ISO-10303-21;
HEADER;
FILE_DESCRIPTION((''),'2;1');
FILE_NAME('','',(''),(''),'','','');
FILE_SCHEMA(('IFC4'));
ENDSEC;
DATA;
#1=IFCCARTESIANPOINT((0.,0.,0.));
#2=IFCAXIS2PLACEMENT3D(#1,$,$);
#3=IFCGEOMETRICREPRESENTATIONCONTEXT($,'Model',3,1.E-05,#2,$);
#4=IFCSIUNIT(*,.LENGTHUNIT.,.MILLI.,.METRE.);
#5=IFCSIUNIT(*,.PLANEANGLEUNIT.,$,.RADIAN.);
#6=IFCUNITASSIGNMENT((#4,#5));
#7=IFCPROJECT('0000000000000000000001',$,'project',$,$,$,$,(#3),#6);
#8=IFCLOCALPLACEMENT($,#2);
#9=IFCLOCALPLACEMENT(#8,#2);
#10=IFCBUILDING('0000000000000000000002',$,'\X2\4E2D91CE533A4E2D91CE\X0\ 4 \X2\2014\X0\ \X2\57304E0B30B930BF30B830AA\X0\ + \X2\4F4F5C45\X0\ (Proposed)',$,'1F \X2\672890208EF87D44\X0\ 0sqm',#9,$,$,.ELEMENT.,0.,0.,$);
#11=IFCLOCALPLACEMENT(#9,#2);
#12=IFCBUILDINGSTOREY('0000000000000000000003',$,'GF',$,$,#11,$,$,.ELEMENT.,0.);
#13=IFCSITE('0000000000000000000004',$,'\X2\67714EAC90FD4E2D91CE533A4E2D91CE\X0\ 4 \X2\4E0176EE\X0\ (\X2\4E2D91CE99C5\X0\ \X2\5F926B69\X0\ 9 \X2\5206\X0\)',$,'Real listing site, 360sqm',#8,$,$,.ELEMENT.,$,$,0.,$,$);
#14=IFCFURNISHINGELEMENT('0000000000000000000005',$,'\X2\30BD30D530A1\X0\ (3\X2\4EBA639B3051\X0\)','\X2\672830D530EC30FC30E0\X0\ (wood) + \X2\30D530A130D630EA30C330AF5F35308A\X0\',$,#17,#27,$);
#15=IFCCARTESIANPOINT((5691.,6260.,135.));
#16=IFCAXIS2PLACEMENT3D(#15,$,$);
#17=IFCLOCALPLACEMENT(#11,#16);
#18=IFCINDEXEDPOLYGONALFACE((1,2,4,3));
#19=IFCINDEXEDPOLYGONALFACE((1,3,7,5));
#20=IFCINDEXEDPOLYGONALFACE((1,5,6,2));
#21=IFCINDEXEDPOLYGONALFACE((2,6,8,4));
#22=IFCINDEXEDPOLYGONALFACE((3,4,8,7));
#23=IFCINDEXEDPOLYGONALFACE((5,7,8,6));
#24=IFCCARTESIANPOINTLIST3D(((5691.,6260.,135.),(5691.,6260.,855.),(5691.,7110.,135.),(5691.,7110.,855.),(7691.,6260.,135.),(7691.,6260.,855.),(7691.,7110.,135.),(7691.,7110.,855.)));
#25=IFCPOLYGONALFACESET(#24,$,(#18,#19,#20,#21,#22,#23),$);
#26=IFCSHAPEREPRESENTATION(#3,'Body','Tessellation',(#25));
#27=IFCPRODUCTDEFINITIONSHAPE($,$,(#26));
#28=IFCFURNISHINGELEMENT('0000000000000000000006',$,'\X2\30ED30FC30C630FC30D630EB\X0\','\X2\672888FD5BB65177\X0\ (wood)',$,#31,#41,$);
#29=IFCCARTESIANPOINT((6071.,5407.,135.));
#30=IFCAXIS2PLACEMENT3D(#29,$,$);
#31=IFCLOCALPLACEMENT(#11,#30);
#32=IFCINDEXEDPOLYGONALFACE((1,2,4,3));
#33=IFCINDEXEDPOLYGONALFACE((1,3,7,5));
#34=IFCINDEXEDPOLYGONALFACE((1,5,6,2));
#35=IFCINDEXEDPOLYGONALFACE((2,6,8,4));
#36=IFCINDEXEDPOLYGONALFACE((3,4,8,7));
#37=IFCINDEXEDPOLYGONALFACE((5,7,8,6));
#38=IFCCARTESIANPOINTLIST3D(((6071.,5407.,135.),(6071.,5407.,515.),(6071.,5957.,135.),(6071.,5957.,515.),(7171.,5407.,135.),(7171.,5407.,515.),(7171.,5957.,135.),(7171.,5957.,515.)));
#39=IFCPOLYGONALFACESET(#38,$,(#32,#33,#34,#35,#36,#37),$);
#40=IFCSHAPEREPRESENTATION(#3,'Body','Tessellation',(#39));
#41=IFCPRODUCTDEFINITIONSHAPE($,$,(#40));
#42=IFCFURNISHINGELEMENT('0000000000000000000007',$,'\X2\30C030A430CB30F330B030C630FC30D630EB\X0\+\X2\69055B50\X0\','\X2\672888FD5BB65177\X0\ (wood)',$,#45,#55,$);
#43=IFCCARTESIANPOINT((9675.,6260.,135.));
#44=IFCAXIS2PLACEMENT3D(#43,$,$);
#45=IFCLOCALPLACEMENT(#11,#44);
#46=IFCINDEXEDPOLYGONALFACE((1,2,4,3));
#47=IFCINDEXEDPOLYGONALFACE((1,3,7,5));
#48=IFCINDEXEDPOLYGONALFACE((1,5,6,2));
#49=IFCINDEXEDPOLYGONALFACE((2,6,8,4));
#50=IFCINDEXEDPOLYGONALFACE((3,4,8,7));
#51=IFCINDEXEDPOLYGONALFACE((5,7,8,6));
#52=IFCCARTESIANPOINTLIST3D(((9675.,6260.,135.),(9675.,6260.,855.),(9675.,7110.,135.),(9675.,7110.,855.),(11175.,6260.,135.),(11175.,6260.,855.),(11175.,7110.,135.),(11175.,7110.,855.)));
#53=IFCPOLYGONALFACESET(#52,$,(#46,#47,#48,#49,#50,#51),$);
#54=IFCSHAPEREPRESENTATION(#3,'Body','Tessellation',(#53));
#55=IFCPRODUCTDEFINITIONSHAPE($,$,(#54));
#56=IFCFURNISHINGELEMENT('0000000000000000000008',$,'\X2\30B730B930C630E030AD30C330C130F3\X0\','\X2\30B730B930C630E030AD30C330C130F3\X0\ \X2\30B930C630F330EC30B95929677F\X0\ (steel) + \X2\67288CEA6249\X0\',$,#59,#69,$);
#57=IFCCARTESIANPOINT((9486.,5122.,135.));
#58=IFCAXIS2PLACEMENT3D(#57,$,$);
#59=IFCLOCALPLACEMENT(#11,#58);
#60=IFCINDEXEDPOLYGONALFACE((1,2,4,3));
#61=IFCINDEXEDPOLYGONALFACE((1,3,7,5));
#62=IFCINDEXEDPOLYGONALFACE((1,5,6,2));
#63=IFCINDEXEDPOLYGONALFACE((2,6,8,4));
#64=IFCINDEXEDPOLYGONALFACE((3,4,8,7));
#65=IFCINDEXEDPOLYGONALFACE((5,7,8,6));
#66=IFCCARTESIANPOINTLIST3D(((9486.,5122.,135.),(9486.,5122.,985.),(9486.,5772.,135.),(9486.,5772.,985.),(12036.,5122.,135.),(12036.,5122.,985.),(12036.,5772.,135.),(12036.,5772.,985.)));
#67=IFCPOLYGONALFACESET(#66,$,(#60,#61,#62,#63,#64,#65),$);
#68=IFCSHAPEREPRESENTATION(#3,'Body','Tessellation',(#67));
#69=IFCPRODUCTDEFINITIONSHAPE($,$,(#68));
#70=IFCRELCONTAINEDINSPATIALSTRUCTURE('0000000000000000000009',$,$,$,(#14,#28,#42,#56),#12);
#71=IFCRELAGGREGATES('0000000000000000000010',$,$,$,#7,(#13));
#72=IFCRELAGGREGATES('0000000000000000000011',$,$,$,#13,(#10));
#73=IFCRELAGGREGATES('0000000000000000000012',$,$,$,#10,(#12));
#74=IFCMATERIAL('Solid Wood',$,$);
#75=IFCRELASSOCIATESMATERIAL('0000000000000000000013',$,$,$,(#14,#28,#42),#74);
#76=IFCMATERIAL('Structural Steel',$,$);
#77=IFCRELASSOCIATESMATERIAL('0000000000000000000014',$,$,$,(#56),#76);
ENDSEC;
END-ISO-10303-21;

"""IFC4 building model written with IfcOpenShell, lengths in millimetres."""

from ifc_helpers import new_model, si_unit, frame, frame_2d, origin, place, context, project, spatial, rectangle, extrude, material, element, save


model = new_model("IFC4")

# Units and contexts
model_context = context("Model", 3, precision=1e-05, world=origin())
ifc_project = project(units=[si_unit("LENGTHUNIT", "METRE", prefix="MILLI"), si_unit("PLANEANGLEUNIT", "RADIAN")], contexts=[model_context])

# Site, building, storey
site_placement = place(None, origin())
site = spatial("IfcSite", under=ifc_project, at=site_placement, Name="東京都中野区中野 4 丁目 (中野駅 徒歩 9 分)", ObjectType="Real listing site, 360sqm", CompositionType="ELEMENT", RefElevation=0.0)
building_placement = place(site_placement, origin())
building = spatial("IfcBuilding", under=site, at=building_placement, Name="中野区中野 4 — 地下スタジオ + 住居 (Proposed)", ObjectType="1F 木造軸組 0sqm", CompositionType="ELEMENT", ElevationOfRefHeight=0.0, ElevationOfTerrain=0.0)
storey_placement = place(building_placement, origin())
storey = spatial("IfcBuildingStorey", under=building, at=storey_placement, Name="GF", CompositionType="ELEMENT", Elevation=0.0)

# Shared definitions
ifc_material_1 = material(Name="Solid Wood")

# Shared definitions
ifc_material_2 = material(Name="Structural Steel")

# Furnishing elements
furnishing_1_placement = place(storey_placement, frame((5691.0, 6260.0, 135.0)))
element("IfcFurnishingElement", 1, at=furnishing_1_placement, inside=storey, material=ifc_material_1, Name="ソファ (3人掛け)", Description="木フレーム (wood) + ファブリック張り", context=model_context, shape_type="SweptSolid", body=[
    extrude(rectangle(XDim=2000.0, YDim=850.0, at=frame_2d((1000.0, 425.0))), frame((5691.0, 6260.0, 135.0)), (0.0, 0.0, 1.0), 720.0),
])
furnishing_2_placement = place(storey_placement, frame((6071.0, 5407.0, 135.0)))
element("IfcFurnishingElement", 2, at=furnishing_2_placement, inside=storey, material=ifc_material_1, Name="ローテーブル", Description="木製家具 (wood)", context=model_context, shape_type="SweptSolid", body=[
    extrude(rectangle(XDim=1100.0, YDim=550.0, at=frame_2d((550.0, 275.0))), frame((6071.0, 5407.0, 135.0)), (0.0, 0.0, 1.0), 380.0),
])
furnishing_3_placement = place(storey_placement, frame((9675.0, 6260.0, 135.0)))
element("IfcFurnishingElement", 3, at=furnishing_3_placement, inside=storey, material=ifc_material_1, Name="ダイニングテーブル+椅子", Description="木製家具 (wood)", context=model_context, shape_type="SweptSolid", body=[
    extrude(rectangle(XDim=1500.0, YDim=850.0, at=frame_2d((750.0, 425.0))), frame((9675.0, 6260.0, 135.0)), (0.0, 0.0, 1.0), 720.0),
])
furnishing_4_placement = place(storey_placement, frame((9486.0, 5122.0, 135.0)))
element("IfcFurnishingElement", 4, at=furnishing_4_placement, inside=storey, material=ifc_material_2, Name="システムキッチン", Description="システムキッチン ステンレス天板 (steel) + 木質扉", context=model_context, shape_type="SweptSolid", body=[
    extrude(rectangle(XDim=2550.0, YDim=650.0, at=frame_2d((1275.0, 325.0))), frame((9486.0, 5122.0, 135.0)), (0.0, 0.0, 1.0), 850.0),
])

save(model, "model.ifc")
